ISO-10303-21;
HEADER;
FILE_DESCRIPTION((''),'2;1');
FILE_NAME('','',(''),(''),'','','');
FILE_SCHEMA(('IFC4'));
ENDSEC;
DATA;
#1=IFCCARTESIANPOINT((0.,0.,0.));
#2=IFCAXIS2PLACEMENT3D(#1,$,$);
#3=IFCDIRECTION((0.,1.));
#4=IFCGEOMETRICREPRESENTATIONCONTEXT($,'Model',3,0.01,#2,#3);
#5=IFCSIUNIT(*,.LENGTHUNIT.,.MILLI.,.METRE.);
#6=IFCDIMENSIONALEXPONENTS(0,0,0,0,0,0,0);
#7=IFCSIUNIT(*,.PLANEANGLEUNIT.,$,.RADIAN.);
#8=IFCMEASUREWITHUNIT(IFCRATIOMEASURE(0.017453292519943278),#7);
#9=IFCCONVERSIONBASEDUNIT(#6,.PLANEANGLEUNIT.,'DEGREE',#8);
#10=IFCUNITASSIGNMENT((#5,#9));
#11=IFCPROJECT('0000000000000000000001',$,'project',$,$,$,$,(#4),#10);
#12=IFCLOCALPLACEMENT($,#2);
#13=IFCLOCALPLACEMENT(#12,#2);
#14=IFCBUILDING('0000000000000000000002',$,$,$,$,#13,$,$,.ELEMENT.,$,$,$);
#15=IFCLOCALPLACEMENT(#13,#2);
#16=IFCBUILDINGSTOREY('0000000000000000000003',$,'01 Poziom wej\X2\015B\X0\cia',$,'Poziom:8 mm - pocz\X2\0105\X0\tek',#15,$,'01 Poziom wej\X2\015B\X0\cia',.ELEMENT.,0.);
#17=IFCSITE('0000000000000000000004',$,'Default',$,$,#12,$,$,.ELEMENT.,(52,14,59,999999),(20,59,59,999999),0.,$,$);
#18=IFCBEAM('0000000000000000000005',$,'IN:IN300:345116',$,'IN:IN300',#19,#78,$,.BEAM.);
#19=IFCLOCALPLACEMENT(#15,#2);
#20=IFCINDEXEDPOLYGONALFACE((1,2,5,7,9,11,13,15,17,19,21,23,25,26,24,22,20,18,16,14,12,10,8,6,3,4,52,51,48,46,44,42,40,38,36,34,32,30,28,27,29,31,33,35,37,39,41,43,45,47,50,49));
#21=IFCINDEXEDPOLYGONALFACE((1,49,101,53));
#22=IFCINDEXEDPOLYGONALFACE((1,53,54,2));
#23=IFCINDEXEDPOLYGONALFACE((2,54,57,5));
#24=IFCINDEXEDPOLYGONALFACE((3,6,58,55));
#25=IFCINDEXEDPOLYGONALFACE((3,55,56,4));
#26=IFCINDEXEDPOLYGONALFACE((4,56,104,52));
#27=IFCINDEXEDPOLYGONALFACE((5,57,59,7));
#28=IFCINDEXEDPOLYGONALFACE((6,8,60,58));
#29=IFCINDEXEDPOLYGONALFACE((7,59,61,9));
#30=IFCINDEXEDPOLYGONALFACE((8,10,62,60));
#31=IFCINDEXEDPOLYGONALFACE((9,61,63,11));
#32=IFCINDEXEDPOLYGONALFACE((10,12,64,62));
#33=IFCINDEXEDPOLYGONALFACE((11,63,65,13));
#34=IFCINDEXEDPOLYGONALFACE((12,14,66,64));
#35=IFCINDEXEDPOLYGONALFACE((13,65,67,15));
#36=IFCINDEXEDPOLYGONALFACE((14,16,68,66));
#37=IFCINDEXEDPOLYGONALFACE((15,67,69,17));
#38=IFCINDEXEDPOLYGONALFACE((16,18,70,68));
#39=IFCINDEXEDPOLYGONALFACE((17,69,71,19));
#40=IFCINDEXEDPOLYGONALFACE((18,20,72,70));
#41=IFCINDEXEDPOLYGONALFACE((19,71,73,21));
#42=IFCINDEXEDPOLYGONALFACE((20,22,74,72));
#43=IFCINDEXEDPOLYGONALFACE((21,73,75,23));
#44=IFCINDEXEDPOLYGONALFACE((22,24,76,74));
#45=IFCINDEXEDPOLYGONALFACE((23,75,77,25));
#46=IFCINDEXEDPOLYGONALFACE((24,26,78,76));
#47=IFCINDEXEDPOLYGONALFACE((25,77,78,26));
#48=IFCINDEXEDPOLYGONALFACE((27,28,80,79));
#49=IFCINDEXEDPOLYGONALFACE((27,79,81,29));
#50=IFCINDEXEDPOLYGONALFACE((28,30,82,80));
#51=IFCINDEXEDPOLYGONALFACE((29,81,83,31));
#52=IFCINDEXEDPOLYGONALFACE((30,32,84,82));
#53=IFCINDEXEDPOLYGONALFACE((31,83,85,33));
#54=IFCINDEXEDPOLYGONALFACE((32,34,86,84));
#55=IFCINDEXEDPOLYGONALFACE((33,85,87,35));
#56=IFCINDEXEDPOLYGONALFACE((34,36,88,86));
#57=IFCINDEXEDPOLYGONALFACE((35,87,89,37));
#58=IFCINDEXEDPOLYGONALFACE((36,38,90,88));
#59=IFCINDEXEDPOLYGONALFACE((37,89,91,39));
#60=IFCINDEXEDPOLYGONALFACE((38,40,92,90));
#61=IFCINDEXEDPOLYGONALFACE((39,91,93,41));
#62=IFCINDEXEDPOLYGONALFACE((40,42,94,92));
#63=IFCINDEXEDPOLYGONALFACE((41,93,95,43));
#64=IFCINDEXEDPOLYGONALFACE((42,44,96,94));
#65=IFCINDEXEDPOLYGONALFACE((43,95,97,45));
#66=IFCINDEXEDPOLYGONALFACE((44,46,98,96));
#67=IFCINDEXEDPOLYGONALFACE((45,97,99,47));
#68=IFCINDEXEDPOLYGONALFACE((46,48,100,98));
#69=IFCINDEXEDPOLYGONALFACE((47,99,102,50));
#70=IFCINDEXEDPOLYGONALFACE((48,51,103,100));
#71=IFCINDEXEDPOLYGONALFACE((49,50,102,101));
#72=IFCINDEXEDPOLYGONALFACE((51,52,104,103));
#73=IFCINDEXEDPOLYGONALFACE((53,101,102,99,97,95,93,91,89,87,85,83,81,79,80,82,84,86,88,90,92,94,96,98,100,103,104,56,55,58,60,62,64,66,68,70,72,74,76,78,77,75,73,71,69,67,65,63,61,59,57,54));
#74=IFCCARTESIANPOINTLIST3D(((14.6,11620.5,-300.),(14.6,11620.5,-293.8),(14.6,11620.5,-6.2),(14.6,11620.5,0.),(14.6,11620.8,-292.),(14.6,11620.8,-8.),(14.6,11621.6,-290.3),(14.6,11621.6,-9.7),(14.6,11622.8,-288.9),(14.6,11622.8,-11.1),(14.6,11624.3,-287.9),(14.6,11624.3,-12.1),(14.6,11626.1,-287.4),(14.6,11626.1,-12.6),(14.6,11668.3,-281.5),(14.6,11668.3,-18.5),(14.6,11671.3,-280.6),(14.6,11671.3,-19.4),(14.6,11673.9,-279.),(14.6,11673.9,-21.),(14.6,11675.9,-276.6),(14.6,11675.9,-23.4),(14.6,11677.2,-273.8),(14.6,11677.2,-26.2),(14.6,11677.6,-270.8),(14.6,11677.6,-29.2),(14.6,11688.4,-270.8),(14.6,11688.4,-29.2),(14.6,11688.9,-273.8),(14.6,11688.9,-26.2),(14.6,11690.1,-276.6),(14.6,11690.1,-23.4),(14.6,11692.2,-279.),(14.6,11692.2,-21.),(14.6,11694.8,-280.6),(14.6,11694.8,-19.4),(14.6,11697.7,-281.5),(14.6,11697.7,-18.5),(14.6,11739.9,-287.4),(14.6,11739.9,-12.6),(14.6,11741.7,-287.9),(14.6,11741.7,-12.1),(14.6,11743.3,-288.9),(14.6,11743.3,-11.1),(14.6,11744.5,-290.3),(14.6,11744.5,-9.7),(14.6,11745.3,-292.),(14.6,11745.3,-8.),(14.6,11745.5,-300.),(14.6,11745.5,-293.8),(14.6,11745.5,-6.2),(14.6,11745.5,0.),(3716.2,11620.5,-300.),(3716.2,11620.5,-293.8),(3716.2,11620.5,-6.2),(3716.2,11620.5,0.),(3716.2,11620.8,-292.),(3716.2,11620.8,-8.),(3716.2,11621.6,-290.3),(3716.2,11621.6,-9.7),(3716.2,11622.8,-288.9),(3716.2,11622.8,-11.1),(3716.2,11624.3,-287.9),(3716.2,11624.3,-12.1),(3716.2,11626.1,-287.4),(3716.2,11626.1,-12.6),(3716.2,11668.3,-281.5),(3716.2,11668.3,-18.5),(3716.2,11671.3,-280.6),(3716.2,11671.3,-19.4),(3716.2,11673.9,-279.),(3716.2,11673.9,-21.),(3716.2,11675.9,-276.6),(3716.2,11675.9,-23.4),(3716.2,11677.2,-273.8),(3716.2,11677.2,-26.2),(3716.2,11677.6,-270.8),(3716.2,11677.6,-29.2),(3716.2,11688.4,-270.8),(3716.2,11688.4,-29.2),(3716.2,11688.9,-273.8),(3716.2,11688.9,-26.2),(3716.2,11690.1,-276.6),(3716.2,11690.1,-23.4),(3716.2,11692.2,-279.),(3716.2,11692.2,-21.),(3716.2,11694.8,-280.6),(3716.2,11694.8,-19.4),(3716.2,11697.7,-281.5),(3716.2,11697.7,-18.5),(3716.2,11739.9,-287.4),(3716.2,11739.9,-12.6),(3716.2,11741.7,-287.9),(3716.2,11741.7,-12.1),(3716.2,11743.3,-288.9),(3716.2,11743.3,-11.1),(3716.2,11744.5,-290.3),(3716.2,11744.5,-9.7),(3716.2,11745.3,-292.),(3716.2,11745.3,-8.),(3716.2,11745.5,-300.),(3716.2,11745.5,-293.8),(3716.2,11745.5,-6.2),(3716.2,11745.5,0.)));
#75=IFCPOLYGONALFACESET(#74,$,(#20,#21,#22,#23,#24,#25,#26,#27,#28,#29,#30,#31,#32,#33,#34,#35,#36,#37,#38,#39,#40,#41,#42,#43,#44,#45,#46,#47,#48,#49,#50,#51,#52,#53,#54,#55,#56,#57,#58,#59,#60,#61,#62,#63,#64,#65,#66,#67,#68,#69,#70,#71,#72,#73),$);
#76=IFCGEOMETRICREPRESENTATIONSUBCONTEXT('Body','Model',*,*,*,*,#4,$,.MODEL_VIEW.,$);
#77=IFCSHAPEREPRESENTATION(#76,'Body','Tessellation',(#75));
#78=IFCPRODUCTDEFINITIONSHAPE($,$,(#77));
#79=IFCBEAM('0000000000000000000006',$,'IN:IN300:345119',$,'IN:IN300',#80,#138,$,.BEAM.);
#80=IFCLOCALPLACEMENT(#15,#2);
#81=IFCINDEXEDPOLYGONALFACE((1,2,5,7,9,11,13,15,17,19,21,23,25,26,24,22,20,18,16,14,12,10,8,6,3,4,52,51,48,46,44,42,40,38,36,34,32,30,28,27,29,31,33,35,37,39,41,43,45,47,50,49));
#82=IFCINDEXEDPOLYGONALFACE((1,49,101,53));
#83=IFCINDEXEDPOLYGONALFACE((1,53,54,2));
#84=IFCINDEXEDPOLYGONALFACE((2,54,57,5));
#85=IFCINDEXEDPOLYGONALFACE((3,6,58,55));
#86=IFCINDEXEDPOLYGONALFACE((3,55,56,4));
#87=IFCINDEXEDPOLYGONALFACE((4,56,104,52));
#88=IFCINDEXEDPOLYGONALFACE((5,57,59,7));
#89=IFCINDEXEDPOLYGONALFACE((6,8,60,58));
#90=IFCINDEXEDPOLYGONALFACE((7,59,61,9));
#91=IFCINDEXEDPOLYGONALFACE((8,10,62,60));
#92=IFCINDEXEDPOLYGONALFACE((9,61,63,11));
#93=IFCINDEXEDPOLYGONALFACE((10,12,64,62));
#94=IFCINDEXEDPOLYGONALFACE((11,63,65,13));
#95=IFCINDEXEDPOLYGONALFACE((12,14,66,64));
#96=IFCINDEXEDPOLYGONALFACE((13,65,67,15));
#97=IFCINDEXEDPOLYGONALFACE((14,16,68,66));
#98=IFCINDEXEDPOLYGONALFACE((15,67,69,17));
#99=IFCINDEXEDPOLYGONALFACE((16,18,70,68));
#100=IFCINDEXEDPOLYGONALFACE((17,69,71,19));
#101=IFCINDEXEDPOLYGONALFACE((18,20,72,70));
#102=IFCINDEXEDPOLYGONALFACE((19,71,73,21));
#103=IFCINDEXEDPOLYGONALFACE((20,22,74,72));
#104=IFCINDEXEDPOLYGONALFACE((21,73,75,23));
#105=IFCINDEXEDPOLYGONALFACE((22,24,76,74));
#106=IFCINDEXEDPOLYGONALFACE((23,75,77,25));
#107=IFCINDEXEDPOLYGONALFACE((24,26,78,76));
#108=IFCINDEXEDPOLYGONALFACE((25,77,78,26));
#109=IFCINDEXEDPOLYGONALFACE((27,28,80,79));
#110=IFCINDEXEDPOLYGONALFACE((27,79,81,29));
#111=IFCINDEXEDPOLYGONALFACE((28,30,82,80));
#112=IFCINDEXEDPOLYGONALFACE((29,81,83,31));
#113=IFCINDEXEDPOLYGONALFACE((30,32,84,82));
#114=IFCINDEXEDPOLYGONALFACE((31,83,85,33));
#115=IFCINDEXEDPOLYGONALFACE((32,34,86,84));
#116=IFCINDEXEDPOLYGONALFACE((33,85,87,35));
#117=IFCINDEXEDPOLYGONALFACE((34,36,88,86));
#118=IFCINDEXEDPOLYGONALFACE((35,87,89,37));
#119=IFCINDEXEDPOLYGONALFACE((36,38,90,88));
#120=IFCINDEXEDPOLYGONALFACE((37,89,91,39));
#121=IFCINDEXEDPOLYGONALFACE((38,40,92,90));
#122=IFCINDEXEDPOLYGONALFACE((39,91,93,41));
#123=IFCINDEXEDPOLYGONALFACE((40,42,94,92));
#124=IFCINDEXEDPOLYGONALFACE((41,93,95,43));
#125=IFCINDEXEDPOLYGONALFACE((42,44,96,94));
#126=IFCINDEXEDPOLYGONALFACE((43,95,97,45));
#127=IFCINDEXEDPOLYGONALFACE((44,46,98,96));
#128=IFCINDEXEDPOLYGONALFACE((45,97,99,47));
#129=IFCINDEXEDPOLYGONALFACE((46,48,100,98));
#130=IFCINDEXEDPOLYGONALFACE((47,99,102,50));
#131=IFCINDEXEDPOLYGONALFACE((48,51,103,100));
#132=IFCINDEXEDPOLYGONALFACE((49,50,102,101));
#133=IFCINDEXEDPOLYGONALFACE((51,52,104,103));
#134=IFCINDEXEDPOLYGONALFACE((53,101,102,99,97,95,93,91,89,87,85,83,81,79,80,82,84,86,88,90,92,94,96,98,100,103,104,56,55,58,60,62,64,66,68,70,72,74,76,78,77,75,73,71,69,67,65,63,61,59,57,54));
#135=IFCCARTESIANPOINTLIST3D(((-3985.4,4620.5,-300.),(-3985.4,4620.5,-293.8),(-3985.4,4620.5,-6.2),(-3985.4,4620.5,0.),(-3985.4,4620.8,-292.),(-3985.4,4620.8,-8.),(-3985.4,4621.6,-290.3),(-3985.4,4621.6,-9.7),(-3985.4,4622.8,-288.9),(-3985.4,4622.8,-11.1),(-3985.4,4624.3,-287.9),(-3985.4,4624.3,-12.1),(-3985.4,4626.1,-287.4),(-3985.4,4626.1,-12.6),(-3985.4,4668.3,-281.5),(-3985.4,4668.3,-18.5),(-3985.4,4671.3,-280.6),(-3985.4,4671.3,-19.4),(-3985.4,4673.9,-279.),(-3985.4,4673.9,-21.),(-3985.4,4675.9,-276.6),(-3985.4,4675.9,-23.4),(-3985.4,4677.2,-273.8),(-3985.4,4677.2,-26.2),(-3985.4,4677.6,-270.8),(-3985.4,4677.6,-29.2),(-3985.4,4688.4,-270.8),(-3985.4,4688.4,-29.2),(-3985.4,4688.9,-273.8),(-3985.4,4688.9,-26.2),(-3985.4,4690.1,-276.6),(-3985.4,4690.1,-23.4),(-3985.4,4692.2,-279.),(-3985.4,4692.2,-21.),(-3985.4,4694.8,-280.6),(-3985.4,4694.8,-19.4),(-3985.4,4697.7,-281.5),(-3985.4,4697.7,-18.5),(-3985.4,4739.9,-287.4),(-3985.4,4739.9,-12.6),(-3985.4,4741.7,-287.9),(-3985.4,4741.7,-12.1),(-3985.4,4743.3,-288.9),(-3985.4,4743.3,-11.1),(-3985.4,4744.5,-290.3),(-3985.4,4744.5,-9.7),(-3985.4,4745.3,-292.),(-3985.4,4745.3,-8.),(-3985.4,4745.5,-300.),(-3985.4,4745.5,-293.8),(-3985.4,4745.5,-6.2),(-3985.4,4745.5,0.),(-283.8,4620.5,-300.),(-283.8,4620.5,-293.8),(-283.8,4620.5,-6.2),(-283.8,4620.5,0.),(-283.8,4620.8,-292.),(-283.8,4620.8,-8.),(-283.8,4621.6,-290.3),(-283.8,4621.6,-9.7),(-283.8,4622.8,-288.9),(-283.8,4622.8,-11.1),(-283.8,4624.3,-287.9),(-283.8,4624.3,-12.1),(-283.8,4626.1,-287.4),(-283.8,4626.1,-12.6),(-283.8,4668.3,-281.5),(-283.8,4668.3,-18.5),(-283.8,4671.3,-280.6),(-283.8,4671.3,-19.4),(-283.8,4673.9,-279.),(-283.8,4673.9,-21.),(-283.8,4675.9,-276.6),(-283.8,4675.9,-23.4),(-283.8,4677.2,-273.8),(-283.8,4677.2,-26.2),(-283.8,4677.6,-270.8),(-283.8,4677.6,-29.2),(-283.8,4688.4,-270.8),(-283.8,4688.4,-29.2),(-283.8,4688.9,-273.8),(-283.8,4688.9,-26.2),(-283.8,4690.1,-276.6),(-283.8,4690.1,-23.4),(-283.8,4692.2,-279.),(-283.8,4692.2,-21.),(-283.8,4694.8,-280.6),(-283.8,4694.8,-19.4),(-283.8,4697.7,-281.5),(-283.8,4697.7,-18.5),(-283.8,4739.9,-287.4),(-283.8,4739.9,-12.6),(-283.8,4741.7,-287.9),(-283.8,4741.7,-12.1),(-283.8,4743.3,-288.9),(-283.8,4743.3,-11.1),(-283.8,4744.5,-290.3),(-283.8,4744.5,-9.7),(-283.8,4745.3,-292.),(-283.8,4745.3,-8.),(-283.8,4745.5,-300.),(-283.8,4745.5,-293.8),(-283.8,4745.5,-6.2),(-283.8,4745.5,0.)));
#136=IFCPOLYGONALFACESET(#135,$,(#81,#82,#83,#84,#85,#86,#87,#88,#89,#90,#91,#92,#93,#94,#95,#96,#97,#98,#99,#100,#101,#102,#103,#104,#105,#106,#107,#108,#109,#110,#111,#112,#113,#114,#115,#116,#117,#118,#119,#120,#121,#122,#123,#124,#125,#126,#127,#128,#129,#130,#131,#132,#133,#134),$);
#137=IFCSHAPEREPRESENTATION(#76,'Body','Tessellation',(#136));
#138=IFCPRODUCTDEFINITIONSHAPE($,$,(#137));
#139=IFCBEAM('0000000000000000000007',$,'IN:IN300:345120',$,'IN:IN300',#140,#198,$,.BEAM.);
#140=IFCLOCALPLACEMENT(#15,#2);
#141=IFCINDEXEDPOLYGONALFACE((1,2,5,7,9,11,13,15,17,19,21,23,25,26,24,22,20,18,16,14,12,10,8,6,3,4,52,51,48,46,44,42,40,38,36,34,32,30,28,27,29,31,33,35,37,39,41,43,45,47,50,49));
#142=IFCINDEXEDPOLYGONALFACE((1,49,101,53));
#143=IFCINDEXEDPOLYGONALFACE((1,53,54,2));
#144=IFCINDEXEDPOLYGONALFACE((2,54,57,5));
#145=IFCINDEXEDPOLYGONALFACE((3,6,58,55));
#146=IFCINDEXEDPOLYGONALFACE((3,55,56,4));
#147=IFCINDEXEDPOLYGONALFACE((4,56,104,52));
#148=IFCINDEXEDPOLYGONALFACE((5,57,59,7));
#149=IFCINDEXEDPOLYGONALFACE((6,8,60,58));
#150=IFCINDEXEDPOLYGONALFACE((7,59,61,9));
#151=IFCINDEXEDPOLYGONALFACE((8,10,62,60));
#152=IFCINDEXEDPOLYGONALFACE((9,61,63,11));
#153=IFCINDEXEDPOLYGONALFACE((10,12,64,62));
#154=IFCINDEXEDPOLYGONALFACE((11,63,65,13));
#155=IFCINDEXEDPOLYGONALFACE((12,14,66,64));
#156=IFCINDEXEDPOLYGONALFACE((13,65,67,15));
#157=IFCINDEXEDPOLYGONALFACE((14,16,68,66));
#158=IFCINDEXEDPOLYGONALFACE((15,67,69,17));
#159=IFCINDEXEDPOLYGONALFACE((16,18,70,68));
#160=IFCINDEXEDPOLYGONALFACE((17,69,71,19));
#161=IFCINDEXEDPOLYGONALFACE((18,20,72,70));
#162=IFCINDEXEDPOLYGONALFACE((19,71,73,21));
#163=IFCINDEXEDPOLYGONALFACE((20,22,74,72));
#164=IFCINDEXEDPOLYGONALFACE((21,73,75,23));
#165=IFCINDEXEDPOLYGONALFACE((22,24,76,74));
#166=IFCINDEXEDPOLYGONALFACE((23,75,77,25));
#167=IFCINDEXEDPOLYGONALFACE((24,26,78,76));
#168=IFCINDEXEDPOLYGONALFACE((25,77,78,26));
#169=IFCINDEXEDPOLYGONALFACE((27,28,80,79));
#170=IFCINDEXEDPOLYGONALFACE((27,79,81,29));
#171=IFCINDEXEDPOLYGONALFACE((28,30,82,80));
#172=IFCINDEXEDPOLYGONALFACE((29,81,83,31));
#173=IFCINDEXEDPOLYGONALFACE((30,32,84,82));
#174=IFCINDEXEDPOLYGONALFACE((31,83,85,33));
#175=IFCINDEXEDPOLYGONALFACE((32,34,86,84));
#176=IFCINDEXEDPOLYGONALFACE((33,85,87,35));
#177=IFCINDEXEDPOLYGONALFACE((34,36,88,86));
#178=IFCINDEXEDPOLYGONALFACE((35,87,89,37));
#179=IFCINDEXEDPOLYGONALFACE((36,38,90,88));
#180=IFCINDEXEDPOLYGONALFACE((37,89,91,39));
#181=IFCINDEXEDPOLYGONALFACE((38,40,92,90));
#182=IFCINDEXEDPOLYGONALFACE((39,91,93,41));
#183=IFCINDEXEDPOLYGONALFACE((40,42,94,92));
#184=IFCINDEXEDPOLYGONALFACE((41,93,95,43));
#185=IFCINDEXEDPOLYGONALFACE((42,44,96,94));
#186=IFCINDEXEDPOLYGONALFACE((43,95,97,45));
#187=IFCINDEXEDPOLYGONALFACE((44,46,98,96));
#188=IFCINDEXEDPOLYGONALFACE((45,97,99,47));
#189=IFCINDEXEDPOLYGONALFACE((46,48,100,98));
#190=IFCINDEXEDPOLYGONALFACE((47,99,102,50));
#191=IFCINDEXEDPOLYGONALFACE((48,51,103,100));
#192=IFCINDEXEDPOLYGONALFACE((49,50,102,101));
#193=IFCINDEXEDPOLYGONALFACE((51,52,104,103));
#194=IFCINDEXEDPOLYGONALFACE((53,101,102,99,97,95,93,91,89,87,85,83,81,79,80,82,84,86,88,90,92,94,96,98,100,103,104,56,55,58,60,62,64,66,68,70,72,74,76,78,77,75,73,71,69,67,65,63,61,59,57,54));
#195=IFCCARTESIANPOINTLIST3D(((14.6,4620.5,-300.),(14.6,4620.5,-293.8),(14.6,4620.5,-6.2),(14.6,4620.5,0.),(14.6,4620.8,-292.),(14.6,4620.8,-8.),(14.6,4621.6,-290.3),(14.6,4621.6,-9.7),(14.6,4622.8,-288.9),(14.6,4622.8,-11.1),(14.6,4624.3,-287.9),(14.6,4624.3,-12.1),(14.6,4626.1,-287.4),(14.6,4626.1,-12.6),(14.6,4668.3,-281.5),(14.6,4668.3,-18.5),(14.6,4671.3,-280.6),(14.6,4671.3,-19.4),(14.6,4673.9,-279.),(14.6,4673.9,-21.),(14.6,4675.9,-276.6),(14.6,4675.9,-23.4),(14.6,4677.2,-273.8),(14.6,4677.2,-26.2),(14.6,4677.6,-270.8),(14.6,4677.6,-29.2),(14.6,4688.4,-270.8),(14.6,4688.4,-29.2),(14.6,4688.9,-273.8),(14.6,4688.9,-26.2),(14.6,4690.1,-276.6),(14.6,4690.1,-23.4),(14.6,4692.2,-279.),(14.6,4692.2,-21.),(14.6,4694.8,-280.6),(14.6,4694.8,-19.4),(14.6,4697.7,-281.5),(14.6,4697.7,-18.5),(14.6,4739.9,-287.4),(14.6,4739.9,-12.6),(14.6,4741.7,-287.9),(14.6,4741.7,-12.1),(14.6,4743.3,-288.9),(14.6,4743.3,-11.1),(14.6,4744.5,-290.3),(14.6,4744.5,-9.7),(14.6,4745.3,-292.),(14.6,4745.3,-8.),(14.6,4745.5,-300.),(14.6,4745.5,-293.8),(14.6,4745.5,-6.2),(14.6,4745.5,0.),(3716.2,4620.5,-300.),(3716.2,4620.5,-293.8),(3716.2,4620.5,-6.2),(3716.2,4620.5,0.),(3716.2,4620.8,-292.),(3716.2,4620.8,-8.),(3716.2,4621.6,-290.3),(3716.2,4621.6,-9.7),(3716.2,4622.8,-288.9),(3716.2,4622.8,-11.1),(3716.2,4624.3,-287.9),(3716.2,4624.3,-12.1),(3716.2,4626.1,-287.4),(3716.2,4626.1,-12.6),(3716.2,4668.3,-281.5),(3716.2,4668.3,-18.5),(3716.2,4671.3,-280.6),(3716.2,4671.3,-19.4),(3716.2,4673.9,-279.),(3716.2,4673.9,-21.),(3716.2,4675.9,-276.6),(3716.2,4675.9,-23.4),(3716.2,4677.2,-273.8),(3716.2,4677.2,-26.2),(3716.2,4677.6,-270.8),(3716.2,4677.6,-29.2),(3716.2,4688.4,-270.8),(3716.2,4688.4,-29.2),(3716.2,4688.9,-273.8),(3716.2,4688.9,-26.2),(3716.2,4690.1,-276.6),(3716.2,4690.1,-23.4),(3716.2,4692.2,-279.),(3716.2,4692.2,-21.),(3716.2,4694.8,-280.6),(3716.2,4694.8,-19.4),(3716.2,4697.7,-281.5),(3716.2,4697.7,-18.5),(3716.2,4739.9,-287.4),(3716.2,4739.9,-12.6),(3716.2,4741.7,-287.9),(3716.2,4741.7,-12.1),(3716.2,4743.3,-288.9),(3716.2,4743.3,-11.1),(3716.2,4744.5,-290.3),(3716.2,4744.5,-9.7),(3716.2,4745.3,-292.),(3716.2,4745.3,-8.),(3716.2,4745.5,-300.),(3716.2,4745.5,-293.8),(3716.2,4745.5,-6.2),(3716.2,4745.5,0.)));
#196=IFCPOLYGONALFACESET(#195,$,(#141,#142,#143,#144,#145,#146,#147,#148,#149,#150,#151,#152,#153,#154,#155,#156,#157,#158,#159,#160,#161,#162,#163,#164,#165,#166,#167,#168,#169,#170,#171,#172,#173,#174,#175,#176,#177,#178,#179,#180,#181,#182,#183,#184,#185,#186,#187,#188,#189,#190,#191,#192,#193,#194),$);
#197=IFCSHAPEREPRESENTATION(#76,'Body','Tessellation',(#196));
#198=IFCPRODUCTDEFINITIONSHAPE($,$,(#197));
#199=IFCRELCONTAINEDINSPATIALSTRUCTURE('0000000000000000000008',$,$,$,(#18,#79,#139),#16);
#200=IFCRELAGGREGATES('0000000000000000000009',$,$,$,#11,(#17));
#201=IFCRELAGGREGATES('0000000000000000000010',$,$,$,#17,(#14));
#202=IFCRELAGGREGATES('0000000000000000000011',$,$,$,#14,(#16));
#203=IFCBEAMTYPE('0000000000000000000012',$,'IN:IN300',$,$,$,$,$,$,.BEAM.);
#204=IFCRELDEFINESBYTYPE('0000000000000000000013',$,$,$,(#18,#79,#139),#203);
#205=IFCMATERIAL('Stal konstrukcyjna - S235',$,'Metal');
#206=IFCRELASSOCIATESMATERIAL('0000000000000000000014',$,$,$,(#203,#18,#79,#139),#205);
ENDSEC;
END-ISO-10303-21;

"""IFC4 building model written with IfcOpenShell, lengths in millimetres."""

from ifc_helpers import new_model, entity, si_unit, converted_unit, direction, frame, origin, place, context, subcontext, project, spatial, line, arc, indexed_curve, outline, extrude, source, transform, mapped, material, type_object, type_shapes, element, save


model = new_model("IFC4")

# Units and contexts
model_context = context("Model", 3, precision=0.01, world=origin(), true_north=direction((0.0, 1.0)))
body_context = subcontext(model_context, "Body", "Model", "MODEL_VIEW")
ifc_project = project(units=[si_unit("LENGTHUNIT", "METRE", prefix="MILLI"), converted_unit("PLANEANGLEUNIT", "DEGREE", entity("IfcRatioMeasure", 0.017453292519943278), si_unit("PLANEANGLEUNIT", "RADIAN"), dimensions=[0, 0, 0, 0, 0, 0, 0])], contexts=[model_context])

# Site, building, storey
site_placement = place(None, origin())
site = spatial("IfcSite", under=ifc_project, at=site_placement, Name="Default", CompositionType="ELEMENT", RefLatitude=(52, 14, 59, 999999), RefLongitude=(20, 59, 59, 999999), RefElevation=0.0)
building_placement = place(site_placement, origin())
building = spatial("IfcBuilding", under=site, at=building_placement, CompositionType="ELEMENT")
storey_placement = place(building_placement, origin())
storey = spatial("IfcBuildingStorey", under=building, at=storey_placement, Name="01 Poziom wejścia", ObjectType="Poziom:8 mm - początek", LongName="01 Poziom wejścia", CompositionType="ELEMENT", Elevation=0.0)

# Beams
ifc_material = material(Name="Stal konstrukcyjna - S235", Category="Metal")
beam_type_1 = type_object("IfcBeamType", Name="IN:IN300", PredefinedType="BEAM", material=ifc_material)
shared_shape_1 = source(origin(), body_context, "Body", "SweptSolid", [
    extrude(outline(indexed_curve([(143.8, -62.5), (150.0, -62.5), (150.0, 62.5), (143.8, 62.5), (139.6, 60.9), (137.4, 56.9), (131.5, 14.7), (127.9, 8.1), (120.8, 5.4), (-120.8, 5.4), (-127.9, 8.1), (-131.5, 14.7), (-137.4, 56.9), (-139.6, 60.9), (-143.8, 62.5), (-150.0, 62.5), (-150.0, -62.5), (-143.8, -62.5), (-139.6, -60.9), (-137.4, -56.9), (-131.5, -14.7), (-127.9, -8.1), (-120.8, -5.4), (120.8, -5.4), (127.9, -8.1), (131.5, -14.7), (137.4, -56.9), (139.6, -60.9)], segments=[line(1, 2, 3, 4), arc(4, 5, 6), line(6, 7), arc(7, 8, 9), line(9, 10), arc(10, 11, 12), line(12, 13), arc(13, 14, 15), line(15, 16, 17, 18), arc(18, 19, 20), line(20, 21), arc(21, 22, 23), line(23, 24), arc(24, 25, 26), line(26, 27), arc(27, 28, 1)], self_intersect=False)), frame((-1850.8, 0.0, 0.0), z_axis=(1.0, 0.0, 0.0), x_axis=(0.0, 0.0, -1.0)), (0.0, 0.0, 1.0), 3701.6),
])
type_shapes(beam_type_1, [shared_shape_1])
for number, where, name in (
    (1, (1865.4, 11683.0, -150.0), "IN:IN300:345116"),
    (2, (-2134.6, 4683.0, -150.0), "IN:IN300:345119"),
    (3, (1865.4, 4683.0, -150.0), "IN:IN300:345120"),
):
    element("IfcBeam", number, at=place(storey_placement, frame(where)), inside=storey, type_object=beam_type_1, material=ifc_material, Name=name, ObjectType="IN:IN300", PredefinedType="BEAM", context=body_context, shape_type="MappedRepresentation", body=[
        mapped(shared_shape_1, transform((0.0, 0.0, 0.0), scale=1.0)),
    ])

save(model, "model.ifc")
